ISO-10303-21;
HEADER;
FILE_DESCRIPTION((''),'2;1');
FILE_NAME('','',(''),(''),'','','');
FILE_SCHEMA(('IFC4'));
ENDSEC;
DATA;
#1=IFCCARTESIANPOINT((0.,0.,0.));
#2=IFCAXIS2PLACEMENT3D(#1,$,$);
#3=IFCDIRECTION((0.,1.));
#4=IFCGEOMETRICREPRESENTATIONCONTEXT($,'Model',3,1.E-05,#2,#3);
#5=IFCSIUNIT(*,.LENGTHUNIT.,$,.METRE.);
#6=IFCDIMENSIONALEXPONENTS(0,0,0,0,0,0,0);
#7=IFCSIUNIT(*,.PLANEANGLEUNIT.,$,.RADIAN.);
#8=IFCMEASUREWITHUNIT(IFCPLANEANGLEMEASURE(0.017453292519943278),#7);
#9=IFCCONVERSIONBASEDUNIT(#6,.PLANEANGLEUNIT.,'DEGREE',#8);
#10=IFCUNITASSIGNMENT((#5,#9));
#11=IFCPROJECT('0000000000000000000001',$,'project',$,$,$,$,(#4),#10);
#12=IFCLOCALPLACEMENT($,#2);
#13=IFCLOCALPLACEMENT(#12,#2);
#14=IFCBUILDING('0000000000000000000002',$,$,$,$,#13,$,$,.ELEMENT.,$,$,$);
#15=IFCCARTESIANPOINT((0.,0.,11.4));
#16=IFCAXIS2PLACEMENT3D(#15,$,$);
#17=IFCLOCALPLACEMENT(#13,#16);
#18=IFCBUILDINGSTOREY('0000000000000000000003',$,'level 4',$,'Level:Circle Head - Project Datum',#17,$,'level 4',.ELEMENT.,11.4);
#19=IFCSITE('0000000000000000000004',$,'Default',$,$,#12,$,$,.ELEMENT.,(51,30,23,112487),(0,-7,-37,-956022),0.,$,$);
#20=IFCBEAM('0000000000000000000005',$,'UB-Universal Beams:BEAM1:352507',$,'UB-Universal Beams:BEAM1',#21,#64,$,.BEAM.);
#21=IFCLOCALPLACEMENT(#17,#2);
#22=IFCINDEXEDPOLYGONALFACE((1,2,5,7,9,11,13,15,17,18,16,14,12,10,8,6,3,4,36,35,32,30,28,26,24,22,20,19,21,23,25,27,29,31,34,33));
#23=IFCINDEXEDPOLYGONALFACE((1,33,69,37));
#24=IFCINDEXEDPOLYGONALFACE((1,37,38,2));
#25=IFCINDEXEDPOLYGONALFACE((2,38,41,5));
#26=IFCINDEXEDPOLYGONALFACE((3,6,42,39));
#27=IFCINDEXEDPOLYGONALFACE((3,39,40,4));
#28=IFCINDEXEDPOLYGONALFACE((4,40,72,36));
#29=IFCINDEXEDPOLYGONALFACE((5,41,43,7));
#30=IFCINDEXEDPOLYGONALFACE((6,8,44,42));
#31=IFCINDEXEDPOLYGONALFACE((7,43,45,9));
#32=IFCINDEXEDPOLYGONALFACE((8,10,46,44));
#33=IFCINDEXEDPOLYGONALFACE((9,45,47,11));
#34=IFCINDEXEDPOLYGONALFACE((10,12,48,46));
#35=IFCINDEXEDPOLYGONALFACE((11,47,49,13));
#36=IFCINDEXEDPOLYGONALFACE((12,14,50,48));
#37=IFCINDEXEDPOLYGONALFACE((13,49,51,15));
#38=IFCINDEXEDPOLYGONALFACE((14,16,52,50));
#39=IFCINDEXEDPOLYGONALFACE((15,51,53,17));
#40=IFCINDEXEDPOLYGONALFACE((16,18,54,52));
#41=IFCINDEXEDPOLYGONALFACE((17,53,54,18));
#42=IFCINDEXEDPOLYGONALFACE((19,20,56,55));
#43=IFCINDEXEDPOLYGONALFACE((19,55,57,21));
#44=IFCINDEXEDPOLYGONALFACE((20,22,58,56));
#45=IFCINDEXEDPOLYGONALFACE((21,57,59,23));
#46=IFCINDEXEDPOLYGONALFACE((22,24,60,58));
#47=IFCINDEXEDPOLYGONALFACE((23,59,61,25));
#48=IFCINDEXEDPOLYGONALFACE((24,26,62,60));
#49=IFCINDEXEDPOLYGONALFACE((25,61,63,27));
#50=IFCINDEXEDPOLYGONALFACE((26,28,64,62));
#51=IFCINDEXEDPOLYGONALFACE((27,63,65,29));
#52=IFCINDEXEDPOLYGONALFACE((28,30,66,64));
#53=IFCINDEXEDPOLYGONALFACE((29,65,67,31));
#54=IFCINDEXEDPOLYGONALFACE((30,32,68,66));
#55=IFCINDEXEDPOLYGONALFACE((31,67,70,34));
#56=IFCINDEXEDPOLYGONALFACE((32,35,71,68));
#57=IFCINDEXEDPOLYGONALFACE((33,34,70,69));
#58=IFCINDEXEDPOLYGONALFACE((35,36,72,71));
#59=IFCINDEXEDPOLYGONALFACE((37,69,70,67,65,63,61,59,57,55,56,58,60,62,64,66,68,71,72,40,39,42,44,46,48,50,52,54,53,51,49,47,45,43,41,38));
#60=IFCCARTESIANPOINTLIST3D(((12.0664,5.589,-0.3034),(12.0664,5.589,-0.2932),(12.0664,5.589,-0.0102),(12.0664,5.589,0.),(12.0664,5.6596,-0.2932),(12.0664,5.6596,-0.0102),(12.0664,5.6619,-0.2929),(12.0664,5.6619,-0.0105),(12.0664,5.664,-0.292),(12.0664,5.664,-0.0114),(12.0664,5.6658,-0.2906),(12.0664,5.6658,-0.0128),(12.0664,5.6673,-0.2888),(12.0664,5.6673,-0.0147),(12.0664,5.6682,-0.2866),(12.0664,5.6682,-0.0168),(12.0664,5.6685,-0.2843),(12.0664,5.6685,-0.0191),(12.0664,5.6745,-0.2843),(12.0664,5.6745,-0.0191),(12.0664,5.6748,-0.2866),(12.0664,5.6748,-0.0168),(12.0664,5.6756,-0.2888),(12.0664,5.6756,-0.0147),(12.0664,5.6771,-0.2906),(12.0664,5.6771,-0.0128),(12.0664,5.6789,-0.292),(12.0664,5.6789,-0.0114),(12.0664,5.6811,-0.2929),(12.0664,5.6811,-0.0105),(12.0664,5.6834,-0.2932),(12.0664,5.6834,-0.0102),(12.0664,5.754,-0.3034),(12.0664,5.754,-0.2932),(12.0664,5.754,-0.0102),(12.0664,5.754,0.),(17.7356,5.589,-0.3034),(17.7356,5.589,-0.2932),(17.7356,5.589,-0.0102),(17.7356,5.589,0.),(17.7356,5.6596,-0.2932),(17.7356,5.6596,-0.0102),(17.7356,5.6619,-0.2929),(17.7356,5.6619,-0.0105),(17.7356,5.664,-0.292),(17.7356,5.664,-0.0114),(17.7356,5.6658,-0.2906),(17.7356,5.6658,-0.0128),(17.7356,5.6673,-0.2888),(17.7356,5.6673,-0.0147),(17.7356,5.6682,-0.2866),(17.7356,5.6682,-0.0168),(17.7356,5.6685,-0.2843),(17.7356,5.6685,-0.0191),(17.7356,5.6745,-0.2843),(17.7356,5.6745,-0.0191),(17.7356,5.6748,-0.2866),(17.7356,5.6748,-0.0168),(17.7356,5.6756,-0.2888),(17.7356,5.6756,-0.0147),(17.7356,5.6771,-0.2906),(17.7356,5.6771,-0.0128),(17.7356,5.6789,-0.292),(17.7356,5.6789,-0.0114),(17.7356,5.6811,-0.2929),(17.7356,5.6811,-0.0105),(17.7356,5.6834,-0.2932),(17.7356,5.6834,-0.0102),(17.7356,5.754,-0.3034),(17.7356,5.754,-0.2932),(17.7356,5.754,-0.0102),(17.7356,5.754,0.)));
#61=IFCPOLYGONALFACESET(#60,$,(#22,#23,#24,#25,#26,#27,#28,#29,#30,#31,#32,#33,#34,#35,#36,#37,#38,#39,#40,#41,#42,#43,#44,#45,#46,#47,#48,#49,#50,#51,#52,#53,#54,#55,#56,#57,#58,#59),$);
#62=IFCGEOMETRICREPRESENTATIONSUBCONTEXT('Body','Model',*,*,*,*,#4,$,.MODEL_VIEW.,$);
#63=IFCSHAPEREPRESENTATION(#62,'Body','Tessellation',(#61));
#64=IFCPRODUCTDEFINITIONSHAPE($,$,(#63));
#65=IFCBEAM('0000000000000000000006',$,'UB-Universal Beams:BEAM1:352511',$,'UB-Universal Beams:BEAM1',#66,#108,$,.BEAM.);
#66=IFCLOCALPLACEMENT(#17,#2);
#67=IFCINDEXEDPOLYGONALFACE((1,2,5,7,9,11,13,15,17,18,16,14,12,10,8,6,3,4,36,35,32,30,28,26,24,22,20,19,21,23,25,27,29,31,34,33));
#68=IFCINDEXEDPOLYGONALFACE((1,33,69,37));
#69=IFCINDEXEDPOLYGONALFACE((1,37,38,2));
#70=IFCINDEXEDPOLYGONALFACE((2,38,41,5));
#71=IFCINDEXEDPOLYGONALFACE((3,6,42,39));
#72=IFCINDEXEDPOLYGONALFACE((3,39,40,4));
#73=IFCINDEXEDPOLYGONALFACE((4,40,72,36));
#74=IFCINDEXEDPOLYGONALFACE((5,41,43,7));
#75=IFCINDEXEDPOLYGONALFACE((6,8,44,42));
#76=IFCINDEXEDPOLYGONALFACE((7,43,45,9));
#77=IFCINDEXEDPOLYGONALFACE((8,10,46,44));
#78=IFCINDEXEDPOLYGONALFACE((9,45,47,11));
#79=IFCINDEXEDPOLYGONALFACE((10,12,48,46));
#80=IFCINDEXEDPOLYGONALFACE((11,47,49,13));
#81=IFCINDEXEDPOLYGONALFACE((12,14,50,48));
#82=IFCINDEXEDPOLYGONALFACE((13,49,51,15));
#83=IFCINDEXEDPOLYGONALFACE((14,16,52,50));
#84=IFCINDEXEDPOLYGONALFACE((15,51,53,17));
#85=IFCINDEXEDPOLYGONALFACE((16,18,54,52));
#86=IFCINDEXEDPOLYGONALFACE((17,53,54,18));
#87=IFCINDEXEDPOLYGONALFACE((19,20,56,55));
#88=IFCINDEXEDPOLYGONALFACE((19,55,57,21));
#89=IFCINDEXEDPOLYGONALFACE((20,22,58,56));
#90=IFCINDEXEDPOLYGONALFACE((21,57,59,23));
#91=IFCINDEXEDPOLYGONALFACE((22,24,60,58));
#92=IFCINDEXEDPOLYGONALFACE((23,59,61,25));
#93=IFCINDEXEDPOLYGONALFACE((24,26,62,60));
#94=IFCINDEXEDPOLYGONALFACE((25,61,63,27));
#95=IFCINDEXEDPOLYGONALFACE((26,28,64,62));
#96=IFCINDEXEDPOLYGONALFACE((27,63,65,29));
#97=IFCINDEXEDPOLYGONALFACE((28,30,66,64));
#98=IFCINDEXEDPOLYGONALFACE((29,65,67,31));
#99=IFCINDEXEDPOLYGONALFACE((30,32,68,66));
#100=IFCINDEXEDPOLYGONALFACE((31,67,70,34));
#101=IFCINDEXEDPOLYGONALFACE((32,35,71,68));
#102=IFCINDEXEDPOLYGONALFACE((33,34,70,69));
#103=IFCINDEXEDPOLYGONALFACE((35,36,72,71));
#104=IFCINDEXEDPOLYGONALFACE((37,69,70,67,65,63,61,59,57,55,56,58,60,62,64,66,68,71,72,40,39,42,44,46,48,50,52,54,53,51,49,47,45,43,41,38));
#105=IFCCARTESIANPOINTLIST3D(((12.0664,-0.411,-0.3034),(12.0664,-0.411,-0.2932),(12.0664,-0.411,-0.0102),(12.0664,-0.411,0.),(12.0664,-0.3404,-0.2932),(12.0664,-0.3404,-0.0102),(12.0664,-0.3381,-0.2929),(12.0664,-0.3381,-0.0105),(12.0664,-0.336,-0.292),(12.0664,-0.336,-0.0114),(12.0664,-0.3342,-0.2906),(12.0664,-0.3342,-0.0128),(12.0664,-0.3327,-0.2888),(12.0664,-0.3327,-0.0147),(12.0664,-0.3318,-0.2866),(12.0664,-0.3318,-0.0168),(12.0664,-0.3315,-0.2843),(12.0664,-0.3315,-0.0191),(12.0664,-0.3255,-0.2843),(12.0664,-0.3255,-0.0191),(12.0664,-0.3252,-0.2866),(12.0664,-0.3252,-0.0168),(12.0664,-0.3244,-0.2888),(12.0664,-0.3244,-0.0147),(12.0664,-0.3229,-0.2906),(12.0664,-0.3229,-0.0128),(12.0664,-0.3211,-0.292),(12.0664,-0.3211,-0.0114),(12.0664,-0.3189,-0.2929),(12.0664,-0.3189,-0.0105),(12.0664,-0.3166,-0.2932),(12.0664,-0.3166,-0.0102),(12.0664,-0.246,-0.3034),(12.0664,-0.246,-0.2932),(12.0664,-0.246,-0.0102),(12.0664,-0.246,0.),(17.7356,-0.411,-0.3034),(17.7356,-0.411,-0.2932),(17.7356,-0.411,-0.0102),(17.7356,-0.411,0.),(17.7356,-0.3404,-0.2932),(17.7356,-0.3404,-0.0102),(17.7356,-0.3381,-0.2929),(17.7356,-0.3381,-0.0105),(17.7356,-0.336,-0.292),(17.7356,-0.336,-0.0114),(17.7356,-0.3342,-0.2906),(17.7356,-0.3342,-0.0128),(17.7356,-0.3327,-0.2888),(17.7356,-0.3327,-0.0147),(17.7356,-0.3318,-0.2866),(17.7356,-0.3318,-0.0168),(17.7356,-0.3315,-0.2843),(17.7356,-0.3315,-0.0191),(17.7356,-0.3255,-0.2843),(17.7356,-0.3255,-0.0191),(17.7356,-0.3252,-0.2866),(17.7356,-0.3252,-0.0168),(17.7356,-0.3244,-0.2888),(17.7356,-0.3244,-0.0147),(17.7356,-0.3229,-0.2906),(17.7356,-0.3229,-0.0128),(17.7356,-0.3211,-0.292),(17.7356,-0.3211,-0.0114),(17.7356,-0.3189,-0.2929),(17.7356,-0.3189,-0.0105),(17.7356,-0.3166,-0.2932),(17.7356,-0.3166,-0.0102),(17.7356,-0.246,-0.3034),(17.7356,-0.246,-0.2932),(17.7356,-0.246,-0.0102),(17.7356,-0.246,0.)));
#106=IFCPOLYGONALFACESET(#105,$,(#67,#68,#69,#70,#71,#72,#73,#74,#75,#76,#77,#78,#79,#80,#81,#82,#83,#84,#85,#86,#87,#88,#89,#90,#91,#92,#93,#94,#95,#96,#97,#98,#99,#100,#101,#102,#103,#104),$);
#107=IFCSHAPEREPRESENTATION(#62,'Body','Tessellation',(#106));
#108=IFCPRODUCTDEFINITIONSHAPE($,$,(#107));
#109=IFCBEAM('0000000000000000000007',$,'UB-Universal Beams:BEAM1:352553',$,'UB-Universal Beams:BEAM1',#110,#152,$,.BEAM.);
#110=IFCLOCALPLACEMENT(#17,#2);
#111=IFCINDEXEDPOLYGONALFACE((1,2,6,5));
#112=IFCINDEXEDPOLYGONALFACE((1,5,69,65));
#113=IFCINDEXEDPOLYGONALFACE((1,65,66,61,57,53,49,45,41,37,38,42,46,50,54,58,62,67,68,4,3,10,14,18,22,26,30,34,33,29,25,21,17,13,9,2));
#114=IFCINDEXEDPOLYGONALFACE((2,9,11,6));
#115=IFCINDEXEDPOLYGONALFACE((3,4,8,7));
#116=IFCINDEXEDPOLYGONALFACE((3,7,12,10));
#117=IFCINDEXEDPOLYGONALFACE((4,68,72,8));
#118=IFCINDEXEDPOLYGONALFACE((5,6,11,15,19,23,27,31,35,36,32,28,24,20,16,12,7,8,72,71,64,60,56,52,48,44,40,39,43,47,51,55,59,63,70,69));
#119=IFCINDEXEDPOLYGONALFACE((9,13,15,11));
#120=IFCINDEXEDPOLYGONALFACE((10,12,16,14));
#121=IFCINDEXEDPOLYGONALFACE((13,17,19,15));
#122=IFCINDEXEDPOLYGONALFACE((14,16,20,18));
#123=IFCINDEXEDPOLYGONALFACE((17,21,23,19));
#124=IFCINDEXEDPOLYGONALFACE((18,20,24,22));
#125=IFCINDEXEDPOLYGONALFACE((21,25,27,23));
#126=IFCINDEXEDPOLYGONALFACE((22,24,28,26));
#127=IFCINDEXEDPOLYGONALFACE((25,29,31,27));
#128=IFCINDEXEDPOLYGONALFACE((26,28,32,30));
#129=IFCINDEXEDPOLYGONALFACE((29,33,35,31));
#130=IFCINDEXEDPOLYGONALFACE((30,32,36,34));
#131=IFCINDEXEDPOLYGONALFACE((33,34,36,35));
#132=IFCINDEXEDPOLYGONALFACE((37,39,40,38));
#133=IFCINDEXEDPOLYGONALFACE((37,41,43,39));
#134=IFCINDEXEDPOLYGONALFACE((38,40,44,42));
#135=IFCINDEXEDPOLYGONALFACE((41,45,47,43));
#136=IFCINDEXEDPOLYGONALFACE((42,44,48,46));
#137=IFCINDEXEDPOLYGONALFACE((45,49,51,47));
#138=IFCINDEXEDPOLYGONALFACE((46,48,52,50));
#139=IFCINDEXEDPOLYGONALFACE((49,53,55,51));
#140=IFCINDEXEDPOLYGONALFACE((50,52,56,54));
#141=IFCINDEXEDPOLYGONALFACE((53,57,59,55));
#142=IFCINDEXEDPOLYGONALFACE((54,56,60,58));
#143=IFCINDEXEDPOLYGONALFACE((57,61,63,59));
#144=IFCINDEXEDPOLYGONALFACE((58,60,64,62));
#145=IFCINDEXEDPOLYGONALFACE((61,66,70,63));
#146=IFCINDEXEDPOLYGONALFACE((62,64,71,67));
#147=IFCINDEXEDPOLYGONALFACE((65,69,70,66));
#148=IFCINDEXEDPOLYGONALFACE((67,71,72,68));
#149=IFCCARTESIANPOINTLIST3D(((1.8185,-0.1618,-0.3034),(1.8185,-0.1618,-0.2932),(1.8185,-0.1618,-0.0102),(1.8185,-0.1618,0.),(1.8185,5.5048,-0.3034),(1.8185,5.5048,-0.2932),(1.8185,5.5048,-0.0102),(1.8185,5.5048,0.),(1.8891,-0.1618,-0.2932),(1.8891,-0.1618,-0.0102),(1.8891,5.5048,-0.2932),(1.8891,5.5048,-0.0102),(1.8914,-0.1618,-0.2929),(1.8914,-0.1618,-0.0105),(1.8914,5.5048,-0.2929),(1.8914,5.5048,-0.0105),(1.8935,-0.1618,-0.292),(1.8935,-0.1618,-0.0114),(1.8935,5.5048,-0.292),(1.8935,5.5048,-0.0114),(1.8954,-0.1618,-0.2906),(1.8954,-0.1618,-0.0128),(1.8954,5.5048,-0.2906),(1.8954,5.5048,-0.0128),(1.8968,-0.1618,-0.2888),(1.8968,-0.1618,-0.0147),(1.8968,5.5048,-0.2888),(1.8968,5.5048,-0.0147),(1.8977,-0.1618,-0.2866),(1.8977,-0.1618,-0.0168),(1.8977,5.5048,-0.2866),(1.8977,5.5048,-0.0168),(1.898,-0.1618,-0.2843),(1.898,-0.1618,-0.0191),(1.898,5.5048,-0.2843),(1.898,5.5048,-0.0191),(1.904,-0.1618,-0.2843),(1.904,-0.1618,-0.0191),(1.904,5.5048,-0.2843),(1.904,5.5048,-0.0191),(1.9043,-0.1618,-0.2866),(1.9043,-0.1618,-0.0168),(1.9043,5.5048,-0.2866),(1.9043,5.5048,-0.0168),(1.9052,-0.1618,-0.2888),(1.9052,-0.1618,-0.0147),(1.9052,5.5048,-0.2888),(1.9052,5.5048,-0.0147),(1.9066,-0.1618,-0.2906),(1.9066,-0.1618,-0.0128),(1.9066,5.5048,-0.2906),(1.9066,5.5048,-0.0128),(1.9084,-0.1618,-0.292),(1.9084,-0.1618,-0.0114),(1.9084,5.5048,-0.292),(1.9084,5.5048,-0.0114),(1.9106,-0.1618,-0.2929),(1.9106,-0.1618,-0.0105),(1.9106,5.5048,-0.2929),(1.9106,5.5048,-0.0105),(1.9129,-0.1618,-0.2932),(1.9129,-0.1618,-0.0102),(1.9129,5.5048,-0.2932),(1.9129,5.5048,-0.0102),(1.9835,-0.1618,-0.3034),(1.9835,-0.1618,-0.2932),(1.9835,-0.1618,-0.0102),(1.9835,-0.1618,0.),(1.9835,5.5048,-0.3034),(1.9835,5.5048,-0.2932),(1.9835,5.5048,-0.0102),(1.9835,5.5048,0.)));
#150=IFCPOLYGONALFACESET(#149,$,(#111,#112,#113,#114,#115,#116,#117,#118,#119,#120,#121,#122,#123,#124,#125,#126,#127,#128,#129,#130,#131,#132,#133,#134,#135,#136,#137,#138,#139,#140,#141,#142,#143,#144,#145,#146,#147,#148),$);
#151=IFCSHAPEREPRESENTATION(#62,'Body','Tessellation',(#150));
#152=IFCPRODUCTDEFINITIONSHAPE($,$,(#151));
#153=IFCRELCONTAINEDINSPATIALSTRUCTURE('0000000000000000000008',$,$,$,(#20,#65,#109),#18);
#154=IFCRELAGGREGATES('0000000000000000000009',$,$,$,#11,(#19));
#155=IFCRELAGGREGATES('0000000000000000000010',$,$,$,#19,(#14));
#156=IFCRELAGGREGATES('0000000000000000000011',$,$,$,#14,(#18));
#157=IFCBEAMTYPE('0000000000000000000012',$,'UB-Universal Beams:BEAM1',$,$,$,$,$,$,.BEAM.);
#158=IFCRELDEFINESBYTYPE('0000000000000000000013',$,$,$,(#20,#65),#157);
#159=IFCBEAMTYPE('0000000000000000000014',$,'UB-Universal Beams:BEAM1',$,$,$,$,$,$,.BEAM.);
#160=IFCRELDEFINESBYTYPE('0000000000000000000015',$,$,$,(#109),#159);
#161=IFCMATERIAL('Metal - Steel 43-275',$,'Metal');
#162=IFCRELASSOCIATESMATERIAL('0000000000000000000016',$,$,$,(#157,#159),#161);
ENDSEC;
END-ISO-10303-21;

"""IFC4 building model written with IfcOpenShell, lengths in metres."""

from ifc_helpers import new_model, entity, si_unit, converted_unit, direction, frame, frame_2d, origin, place, context, subcontext, project, spatial, polyline, circle_curve, parameter, trimmed, segment, composite_curve, outline, extrude, source, transform, mapped, material, material_profile, profile_set, type_object, type_shapes, element, save


model = new_model("IFC4")

# Units and contexts
model_context = context("Model", 3, precision=1e-05, world=origin(), true_north=direction((0.0, 1.0)))
body_context = subcontext(model_context, "Body", "Model", "MODEL_VIEW")
ifc_project = project(units=[si_unit("LENGTHUNIT", "METRE"), converted_unit("PLANEANGLEUNIT", "DEGREE", entity("IfcPlaneAngleMeasure", 0.017453292519943278), si_unit("PLANEANGLEUNIT", "RADIAN"), dimensions=[0, 0, 0, 0, 0, 0, 0])], contexts=[model_context])

# Site, building, storey
site_placement = place(None, origin())
site = spatial("IfcSite", under=ifc_project, at=site_placement, Name="Default", CompositionType="ELEMENT", RefLatitude=(51, 30, 23, 112487), RefLongitude=(0, -7, -37, -956022), RefElevation=0.0)
building_placement = place(site_placement, origin())
building = spatial("IfcBuilding", under=site, at=building_placement, CompositionType="ELEMENT")
storey_placement = place(building_placement, frame((0.0, 0.0, 11.4)))
storey = spatial("IfcBuildingStorey", under=building, at=storey_placement, Name="level 4", ObjectType="Level:Circle Head - Project Datum", LongName="level 4", CompositionType="ELEMENT", Elevation=11.4)

# Shared definitions
ifc_material_1 = material(Name="Metal - Steel 43-275", Category="Metal")

# Beams
ifc_material_profile_1 = material_profile(ifc_material_1, outline(composite_curve([segment(polyline([(-0.0825, -0.1415), (-0.0825, -0.1517)]), True, "CONTINUOUS"), segment(polyline([(-0.0825, -0.1517), (0.0825, -0.1517)]), True, "CONTINUOUS"), segment(polyline([(0.0825, -0.1517), (0.0825, -0.1415)]), True, "CONTINUOUS"), segment(polyline([(0.0825, -0.1415), (0.0119, -0.1415)]), True, "CONTINUOUS"), segment(trimmed(circle_curve(frame_2d((0.0119, -0.1326), x_axis=(1.0, 0.0)), 0.0089), [parameter(180.0)], [parameter(270.0)], True, "PARAMETER"), False, "CONTINUOUS"), segment(polyline([(0.003, -0.1326), (0.003, 0.1326)]), True, "CONTINUOUS"), segment(trimmed(circle_curve(frame_2d((0.0119, 0.1326), x_axis=(1.0, 0.0)), 0.0089), [parameter(90.0)], [parameter(180.0)], True, "PARAMETER"), False, "CONTINUOUS"), segment(polyline([(0.0119, 0.1415), (0.0825, 0.1415)]), True, "CONTINUOUS"), segment(polyline([(0.0825, 0.1415), (0.0825, 0.1517)]), True, "CONTINUOUS"), segment(polyline([(0.0825, 0.1517), (-0.0825, 0.1517)]), True, "CONTINUOUS"), segment(polyline([(-0.0825, 0.1517), (-0.0825, 0.1415)]), True, "CONTINUOUS"), segment(polyline([(-0.0825, 0.1415), (-0.0119, 0.1415)]), True, "CONTINUOUS"), segment(trimmed(circle_curve(frame_2d((-0.0119, 0.1326), x_axis=(1.0, 0.0)), 0.0089), [parameter(360.0)], [parameter(90.0)], True, "PARAMETER"), False, "CONTINUOUS"), segment(polyline([(-0.003, 0.1326), (-0.003, -0.1326)]), True, "CONTINUOUS"), segment(trimmed(circle_curve(frame_2d((-0.0119, -0.1326), x_axis=(1.0, 0.0)), 0.0089), [parameter(270.0)], [parameter(360.0)], True, "PARAMETER"), False, "CONTINUOUS"), segment(polyline([(-0.0119, -0.1415), (-0.0825, -0.1415)]), True, "CONTINUOUS")], self_intersect=False)), Name="BEAM1")
ifc_profile_set_1 = profile_set([ifc_material_profile_1], Name="BEAM1")
beam_type_1 = type_object("IfcBeamType", Name="UB-Universal Beams:BEAM1", PredefinedType="BEAM", material=ifc_profile_set_1)
shared_shape_1 = source(origin(), body_context, "Body", "SweptSolid", [
    extrude(outline(composite_curve([segment(polyline([(-0.0825, -0.1415), (-0.0825, -0.1517)]), True, "CONTINUOUS"), segment(polyline([(-0.0825, -0.1517), (0.0825, -0.1517)]), True, "CONTINUOUS"), segment(polyline([(0.0825, -0.1517), (0.0825, -0.1415)]), True, "CONTINUOUS"), segment(polyline([(0.0825, -0.1415), (0.0119, -0.1415)]), True, "CONTINUOUS"), segment(trimmed(circle_curve(frame_2d((0.0119, -0.1326), x_axis=(0.0, -1.0)), 0.0089), [parameter(270.0)], [parameter(360.0)], True, "PARAMETER"), False, "CONTINUOUS"), segment(polyline([(0.003, -0.1326), (0.003, 0.1326)]), True, "CONTINUOUS"), segment(trimmed(circle_curve(frame_2d((0.0119, 0.1326), x_axis=(-1.0, 0.0)), 0.0089), [parameter(270.0)], [parameter(360.0)], True, "PARAMETER"), False, "CONTINUOUS"), segment(polyline([(0.0119, 0.1415), (0.0825, 0.1415)]), True, "CONTINUOUS"), segment(polyline([(0.0825, 0.1415), (0.0825, 0.1517)]), True, "CONTINUOUS"), segment(polyline([(0.0825, 0.1517), (-0.0825, 0.1517)]), True, "CONTINUOUS"), segment(polyline([(-0.0825, 0.1517), (-0.0825, 0.1415)]), True, "CONTINUOUS"), segment(polyline([(-0.0825, 0.1415), (-0.0119, 0.1415)]), True, "CONTINUOUS"), segment(trimmed(circle_curve(frame_2d((-0.0119, 0.1326), x_axis=(0.0, 1.0)), 0.0089), [parameter(270.0)], [parameter(360.0)], True, "PARAMETER"), False, "CONTINUOUS"), segment(polyline([(-0.003, 0.1326), (-0.003, -0.1326)]), True, "CONTINUOUS"), segment(trimmed(circle_curve(frame_2d((-0.0119, -0.1326), x_axis=(1.0, 0.0)), 0.0089), [parameter(270.0)], [parameter(0.0)], True, "PARAMETER"), False, "CONTINUOUS"), segment(polyline([(-0.0119, -0.1415), (-0.0825, -0.1415)]), True, "CONTINUOUS")], self_intersect=False)), frame((-2.8346, 0.0, 0.0), z_axis=(-1.0, 0.0, 0.0), x_axis=(0.0, -1.0, 0.0)), (0.0, 0.0, -1.0), 5.6692),
])
type_shapes(beam_type_1, [shared_shape_1])
for number, where, name in (
    (1, (14.901, 5.6715, -0.1517), "UB-Universal Beams:BEAM1:352507"),
    (2, (14.901, -0.3285, -0.1517), "UB-Universal Beams:BEAM1:352511"),
):
    element("IfcBeam", number, at=place(storey_placement, frame(where)), inside=storey, type_object=beam_type_1, Name=name, ObjectType="UB-Universal Beams:BEAM1", PredefinedType="BEAM", context=body_context, shape_type="MappedRepresentation", body=[
        mapped(shared_shape_1, transform((0.0, 0.0, 0.0), scale=1.0)),
    ])
beam_type_2 = type_object("IfcBeamType", Name="UB-Universal Beams:BEAM1", PredefinedType="BEAM", material=ifc_profile_set_1)
shared_shape_2 = source(origin(), body_context, "Body", "SweptSolid", [
    extrude(outline(composite_curve([segment(polyline([(-0.0825, -0.1415), (-0.0825, -0.1517)]), True, "CONTINUOUS"), segment(polyline([(-0.0825, -0.1517), (0.0825, -0.1517)]), True, "CONTINUOUS"), segment(polyline([(0.0825, -0.1517), (0.0825, -0.1415)]), True, "CONTINUOUS"), segment(polyline([(0.0825, -0.1415), (0.0119, -0.1415)]), True, "CONTINUOUS"), segment(trimmed(circle_curve(frame_2d((0.0119, -0.1326), x_axis=(1.0, 0.0)), 0.0089), [parameter(180.0)], [parameter(270.0)], True, "PARAMETER"), False, "CONTINUOUS"), segment(polyline([(0.003, -0.1326), (0.003, 0.1326)]), True, "CONTINUOUS"), segment(trimmed(circle_curve(frame_2d((0.0119, 0.1326), x_axis=(1.0, 0.0)), 0.0089), [parameter(90.0)], [parameter(180.0)], True, "PARAMETER"), False, "CONTINUOUS"), segment(polyline([(0.0119, 0.1415), (0.0825, 0.1415)]), True, "CONTINUOUS"), segment(polyline([(0.0825, 0.1415), (0.0825, 0.1517)]), True, "CONTINUOUS"), segment(polyline([(0.0825, 0.1517), (-0.0825, 0.1517)]), True, "CONTINUOUS"), segment(polyline([(-0.0825, 0.1517), (-0.0825, 0.1415)]), True, "CONTINUOUS"), segment(polyline([(-0.0825, 0.1415), (-0.0119, 0.1415)]), True, "CONTINUOUS"), segment(trimmed(circle_curve(frame_2d((-0.0119, 0.1326), x_axis=(1.0, 0.0)), 0.0089), [parameter(360.0)], [parameter(90.0)], True, "PARAMETER"), False, "CONTINUOUS"), segment(polyline([(-0.003, 0.1326), (-0.003, -0.1326)]), True, "CONTINUOUS"), segment(trimmed(circle_curve(frame_2d((-0.0119, -0.1326), x_axis=(1.0, 0.0)), 0.0089), [parameter(270.0)], [parameter(360.0)], True, "PARAMETER"), False, "CONTINUOUS"), segment(polyline([(-0.0119, -0.1415), (-0.0825, -0.1415)]), True, "CONTINUOUS")], self_intersect=False)), frame((-2.8333, 0.0, 0.0), z_axis=(-1.0, 0.0, 0.0), x_axis=(0.0, -1.0, 0.0)), (0.0, 0.0, -1.0), 5.6666),
])
type_shapes(beam_type_2, [shared_shape_2])
for number, where, z_axis, x_axis, name in (
    (3, (1.901, 2.6715, -0.1517), (0.0, 0.0, 1.0), (0.0, -1.0, 0.0), "UB-Universal Beams:BEAM1:352553"),
):
    element("IfcBeam", number, at=place(storey_placement, frame(where, z_axis=z_axis, x_axis=x_axis)), inside=storey, type_object=beam_type_2, Name=name, ObjectType="UB-Universal Beams:BEAM1", PredefinedType="BEAM", context=body_context, shape_type="MappedRepresentation", body=[
        mapped(shared_shape_2, transform((0.0, 0.0, 0.0), scale=1.0)),
    ])

save(model, "model.ifc")
